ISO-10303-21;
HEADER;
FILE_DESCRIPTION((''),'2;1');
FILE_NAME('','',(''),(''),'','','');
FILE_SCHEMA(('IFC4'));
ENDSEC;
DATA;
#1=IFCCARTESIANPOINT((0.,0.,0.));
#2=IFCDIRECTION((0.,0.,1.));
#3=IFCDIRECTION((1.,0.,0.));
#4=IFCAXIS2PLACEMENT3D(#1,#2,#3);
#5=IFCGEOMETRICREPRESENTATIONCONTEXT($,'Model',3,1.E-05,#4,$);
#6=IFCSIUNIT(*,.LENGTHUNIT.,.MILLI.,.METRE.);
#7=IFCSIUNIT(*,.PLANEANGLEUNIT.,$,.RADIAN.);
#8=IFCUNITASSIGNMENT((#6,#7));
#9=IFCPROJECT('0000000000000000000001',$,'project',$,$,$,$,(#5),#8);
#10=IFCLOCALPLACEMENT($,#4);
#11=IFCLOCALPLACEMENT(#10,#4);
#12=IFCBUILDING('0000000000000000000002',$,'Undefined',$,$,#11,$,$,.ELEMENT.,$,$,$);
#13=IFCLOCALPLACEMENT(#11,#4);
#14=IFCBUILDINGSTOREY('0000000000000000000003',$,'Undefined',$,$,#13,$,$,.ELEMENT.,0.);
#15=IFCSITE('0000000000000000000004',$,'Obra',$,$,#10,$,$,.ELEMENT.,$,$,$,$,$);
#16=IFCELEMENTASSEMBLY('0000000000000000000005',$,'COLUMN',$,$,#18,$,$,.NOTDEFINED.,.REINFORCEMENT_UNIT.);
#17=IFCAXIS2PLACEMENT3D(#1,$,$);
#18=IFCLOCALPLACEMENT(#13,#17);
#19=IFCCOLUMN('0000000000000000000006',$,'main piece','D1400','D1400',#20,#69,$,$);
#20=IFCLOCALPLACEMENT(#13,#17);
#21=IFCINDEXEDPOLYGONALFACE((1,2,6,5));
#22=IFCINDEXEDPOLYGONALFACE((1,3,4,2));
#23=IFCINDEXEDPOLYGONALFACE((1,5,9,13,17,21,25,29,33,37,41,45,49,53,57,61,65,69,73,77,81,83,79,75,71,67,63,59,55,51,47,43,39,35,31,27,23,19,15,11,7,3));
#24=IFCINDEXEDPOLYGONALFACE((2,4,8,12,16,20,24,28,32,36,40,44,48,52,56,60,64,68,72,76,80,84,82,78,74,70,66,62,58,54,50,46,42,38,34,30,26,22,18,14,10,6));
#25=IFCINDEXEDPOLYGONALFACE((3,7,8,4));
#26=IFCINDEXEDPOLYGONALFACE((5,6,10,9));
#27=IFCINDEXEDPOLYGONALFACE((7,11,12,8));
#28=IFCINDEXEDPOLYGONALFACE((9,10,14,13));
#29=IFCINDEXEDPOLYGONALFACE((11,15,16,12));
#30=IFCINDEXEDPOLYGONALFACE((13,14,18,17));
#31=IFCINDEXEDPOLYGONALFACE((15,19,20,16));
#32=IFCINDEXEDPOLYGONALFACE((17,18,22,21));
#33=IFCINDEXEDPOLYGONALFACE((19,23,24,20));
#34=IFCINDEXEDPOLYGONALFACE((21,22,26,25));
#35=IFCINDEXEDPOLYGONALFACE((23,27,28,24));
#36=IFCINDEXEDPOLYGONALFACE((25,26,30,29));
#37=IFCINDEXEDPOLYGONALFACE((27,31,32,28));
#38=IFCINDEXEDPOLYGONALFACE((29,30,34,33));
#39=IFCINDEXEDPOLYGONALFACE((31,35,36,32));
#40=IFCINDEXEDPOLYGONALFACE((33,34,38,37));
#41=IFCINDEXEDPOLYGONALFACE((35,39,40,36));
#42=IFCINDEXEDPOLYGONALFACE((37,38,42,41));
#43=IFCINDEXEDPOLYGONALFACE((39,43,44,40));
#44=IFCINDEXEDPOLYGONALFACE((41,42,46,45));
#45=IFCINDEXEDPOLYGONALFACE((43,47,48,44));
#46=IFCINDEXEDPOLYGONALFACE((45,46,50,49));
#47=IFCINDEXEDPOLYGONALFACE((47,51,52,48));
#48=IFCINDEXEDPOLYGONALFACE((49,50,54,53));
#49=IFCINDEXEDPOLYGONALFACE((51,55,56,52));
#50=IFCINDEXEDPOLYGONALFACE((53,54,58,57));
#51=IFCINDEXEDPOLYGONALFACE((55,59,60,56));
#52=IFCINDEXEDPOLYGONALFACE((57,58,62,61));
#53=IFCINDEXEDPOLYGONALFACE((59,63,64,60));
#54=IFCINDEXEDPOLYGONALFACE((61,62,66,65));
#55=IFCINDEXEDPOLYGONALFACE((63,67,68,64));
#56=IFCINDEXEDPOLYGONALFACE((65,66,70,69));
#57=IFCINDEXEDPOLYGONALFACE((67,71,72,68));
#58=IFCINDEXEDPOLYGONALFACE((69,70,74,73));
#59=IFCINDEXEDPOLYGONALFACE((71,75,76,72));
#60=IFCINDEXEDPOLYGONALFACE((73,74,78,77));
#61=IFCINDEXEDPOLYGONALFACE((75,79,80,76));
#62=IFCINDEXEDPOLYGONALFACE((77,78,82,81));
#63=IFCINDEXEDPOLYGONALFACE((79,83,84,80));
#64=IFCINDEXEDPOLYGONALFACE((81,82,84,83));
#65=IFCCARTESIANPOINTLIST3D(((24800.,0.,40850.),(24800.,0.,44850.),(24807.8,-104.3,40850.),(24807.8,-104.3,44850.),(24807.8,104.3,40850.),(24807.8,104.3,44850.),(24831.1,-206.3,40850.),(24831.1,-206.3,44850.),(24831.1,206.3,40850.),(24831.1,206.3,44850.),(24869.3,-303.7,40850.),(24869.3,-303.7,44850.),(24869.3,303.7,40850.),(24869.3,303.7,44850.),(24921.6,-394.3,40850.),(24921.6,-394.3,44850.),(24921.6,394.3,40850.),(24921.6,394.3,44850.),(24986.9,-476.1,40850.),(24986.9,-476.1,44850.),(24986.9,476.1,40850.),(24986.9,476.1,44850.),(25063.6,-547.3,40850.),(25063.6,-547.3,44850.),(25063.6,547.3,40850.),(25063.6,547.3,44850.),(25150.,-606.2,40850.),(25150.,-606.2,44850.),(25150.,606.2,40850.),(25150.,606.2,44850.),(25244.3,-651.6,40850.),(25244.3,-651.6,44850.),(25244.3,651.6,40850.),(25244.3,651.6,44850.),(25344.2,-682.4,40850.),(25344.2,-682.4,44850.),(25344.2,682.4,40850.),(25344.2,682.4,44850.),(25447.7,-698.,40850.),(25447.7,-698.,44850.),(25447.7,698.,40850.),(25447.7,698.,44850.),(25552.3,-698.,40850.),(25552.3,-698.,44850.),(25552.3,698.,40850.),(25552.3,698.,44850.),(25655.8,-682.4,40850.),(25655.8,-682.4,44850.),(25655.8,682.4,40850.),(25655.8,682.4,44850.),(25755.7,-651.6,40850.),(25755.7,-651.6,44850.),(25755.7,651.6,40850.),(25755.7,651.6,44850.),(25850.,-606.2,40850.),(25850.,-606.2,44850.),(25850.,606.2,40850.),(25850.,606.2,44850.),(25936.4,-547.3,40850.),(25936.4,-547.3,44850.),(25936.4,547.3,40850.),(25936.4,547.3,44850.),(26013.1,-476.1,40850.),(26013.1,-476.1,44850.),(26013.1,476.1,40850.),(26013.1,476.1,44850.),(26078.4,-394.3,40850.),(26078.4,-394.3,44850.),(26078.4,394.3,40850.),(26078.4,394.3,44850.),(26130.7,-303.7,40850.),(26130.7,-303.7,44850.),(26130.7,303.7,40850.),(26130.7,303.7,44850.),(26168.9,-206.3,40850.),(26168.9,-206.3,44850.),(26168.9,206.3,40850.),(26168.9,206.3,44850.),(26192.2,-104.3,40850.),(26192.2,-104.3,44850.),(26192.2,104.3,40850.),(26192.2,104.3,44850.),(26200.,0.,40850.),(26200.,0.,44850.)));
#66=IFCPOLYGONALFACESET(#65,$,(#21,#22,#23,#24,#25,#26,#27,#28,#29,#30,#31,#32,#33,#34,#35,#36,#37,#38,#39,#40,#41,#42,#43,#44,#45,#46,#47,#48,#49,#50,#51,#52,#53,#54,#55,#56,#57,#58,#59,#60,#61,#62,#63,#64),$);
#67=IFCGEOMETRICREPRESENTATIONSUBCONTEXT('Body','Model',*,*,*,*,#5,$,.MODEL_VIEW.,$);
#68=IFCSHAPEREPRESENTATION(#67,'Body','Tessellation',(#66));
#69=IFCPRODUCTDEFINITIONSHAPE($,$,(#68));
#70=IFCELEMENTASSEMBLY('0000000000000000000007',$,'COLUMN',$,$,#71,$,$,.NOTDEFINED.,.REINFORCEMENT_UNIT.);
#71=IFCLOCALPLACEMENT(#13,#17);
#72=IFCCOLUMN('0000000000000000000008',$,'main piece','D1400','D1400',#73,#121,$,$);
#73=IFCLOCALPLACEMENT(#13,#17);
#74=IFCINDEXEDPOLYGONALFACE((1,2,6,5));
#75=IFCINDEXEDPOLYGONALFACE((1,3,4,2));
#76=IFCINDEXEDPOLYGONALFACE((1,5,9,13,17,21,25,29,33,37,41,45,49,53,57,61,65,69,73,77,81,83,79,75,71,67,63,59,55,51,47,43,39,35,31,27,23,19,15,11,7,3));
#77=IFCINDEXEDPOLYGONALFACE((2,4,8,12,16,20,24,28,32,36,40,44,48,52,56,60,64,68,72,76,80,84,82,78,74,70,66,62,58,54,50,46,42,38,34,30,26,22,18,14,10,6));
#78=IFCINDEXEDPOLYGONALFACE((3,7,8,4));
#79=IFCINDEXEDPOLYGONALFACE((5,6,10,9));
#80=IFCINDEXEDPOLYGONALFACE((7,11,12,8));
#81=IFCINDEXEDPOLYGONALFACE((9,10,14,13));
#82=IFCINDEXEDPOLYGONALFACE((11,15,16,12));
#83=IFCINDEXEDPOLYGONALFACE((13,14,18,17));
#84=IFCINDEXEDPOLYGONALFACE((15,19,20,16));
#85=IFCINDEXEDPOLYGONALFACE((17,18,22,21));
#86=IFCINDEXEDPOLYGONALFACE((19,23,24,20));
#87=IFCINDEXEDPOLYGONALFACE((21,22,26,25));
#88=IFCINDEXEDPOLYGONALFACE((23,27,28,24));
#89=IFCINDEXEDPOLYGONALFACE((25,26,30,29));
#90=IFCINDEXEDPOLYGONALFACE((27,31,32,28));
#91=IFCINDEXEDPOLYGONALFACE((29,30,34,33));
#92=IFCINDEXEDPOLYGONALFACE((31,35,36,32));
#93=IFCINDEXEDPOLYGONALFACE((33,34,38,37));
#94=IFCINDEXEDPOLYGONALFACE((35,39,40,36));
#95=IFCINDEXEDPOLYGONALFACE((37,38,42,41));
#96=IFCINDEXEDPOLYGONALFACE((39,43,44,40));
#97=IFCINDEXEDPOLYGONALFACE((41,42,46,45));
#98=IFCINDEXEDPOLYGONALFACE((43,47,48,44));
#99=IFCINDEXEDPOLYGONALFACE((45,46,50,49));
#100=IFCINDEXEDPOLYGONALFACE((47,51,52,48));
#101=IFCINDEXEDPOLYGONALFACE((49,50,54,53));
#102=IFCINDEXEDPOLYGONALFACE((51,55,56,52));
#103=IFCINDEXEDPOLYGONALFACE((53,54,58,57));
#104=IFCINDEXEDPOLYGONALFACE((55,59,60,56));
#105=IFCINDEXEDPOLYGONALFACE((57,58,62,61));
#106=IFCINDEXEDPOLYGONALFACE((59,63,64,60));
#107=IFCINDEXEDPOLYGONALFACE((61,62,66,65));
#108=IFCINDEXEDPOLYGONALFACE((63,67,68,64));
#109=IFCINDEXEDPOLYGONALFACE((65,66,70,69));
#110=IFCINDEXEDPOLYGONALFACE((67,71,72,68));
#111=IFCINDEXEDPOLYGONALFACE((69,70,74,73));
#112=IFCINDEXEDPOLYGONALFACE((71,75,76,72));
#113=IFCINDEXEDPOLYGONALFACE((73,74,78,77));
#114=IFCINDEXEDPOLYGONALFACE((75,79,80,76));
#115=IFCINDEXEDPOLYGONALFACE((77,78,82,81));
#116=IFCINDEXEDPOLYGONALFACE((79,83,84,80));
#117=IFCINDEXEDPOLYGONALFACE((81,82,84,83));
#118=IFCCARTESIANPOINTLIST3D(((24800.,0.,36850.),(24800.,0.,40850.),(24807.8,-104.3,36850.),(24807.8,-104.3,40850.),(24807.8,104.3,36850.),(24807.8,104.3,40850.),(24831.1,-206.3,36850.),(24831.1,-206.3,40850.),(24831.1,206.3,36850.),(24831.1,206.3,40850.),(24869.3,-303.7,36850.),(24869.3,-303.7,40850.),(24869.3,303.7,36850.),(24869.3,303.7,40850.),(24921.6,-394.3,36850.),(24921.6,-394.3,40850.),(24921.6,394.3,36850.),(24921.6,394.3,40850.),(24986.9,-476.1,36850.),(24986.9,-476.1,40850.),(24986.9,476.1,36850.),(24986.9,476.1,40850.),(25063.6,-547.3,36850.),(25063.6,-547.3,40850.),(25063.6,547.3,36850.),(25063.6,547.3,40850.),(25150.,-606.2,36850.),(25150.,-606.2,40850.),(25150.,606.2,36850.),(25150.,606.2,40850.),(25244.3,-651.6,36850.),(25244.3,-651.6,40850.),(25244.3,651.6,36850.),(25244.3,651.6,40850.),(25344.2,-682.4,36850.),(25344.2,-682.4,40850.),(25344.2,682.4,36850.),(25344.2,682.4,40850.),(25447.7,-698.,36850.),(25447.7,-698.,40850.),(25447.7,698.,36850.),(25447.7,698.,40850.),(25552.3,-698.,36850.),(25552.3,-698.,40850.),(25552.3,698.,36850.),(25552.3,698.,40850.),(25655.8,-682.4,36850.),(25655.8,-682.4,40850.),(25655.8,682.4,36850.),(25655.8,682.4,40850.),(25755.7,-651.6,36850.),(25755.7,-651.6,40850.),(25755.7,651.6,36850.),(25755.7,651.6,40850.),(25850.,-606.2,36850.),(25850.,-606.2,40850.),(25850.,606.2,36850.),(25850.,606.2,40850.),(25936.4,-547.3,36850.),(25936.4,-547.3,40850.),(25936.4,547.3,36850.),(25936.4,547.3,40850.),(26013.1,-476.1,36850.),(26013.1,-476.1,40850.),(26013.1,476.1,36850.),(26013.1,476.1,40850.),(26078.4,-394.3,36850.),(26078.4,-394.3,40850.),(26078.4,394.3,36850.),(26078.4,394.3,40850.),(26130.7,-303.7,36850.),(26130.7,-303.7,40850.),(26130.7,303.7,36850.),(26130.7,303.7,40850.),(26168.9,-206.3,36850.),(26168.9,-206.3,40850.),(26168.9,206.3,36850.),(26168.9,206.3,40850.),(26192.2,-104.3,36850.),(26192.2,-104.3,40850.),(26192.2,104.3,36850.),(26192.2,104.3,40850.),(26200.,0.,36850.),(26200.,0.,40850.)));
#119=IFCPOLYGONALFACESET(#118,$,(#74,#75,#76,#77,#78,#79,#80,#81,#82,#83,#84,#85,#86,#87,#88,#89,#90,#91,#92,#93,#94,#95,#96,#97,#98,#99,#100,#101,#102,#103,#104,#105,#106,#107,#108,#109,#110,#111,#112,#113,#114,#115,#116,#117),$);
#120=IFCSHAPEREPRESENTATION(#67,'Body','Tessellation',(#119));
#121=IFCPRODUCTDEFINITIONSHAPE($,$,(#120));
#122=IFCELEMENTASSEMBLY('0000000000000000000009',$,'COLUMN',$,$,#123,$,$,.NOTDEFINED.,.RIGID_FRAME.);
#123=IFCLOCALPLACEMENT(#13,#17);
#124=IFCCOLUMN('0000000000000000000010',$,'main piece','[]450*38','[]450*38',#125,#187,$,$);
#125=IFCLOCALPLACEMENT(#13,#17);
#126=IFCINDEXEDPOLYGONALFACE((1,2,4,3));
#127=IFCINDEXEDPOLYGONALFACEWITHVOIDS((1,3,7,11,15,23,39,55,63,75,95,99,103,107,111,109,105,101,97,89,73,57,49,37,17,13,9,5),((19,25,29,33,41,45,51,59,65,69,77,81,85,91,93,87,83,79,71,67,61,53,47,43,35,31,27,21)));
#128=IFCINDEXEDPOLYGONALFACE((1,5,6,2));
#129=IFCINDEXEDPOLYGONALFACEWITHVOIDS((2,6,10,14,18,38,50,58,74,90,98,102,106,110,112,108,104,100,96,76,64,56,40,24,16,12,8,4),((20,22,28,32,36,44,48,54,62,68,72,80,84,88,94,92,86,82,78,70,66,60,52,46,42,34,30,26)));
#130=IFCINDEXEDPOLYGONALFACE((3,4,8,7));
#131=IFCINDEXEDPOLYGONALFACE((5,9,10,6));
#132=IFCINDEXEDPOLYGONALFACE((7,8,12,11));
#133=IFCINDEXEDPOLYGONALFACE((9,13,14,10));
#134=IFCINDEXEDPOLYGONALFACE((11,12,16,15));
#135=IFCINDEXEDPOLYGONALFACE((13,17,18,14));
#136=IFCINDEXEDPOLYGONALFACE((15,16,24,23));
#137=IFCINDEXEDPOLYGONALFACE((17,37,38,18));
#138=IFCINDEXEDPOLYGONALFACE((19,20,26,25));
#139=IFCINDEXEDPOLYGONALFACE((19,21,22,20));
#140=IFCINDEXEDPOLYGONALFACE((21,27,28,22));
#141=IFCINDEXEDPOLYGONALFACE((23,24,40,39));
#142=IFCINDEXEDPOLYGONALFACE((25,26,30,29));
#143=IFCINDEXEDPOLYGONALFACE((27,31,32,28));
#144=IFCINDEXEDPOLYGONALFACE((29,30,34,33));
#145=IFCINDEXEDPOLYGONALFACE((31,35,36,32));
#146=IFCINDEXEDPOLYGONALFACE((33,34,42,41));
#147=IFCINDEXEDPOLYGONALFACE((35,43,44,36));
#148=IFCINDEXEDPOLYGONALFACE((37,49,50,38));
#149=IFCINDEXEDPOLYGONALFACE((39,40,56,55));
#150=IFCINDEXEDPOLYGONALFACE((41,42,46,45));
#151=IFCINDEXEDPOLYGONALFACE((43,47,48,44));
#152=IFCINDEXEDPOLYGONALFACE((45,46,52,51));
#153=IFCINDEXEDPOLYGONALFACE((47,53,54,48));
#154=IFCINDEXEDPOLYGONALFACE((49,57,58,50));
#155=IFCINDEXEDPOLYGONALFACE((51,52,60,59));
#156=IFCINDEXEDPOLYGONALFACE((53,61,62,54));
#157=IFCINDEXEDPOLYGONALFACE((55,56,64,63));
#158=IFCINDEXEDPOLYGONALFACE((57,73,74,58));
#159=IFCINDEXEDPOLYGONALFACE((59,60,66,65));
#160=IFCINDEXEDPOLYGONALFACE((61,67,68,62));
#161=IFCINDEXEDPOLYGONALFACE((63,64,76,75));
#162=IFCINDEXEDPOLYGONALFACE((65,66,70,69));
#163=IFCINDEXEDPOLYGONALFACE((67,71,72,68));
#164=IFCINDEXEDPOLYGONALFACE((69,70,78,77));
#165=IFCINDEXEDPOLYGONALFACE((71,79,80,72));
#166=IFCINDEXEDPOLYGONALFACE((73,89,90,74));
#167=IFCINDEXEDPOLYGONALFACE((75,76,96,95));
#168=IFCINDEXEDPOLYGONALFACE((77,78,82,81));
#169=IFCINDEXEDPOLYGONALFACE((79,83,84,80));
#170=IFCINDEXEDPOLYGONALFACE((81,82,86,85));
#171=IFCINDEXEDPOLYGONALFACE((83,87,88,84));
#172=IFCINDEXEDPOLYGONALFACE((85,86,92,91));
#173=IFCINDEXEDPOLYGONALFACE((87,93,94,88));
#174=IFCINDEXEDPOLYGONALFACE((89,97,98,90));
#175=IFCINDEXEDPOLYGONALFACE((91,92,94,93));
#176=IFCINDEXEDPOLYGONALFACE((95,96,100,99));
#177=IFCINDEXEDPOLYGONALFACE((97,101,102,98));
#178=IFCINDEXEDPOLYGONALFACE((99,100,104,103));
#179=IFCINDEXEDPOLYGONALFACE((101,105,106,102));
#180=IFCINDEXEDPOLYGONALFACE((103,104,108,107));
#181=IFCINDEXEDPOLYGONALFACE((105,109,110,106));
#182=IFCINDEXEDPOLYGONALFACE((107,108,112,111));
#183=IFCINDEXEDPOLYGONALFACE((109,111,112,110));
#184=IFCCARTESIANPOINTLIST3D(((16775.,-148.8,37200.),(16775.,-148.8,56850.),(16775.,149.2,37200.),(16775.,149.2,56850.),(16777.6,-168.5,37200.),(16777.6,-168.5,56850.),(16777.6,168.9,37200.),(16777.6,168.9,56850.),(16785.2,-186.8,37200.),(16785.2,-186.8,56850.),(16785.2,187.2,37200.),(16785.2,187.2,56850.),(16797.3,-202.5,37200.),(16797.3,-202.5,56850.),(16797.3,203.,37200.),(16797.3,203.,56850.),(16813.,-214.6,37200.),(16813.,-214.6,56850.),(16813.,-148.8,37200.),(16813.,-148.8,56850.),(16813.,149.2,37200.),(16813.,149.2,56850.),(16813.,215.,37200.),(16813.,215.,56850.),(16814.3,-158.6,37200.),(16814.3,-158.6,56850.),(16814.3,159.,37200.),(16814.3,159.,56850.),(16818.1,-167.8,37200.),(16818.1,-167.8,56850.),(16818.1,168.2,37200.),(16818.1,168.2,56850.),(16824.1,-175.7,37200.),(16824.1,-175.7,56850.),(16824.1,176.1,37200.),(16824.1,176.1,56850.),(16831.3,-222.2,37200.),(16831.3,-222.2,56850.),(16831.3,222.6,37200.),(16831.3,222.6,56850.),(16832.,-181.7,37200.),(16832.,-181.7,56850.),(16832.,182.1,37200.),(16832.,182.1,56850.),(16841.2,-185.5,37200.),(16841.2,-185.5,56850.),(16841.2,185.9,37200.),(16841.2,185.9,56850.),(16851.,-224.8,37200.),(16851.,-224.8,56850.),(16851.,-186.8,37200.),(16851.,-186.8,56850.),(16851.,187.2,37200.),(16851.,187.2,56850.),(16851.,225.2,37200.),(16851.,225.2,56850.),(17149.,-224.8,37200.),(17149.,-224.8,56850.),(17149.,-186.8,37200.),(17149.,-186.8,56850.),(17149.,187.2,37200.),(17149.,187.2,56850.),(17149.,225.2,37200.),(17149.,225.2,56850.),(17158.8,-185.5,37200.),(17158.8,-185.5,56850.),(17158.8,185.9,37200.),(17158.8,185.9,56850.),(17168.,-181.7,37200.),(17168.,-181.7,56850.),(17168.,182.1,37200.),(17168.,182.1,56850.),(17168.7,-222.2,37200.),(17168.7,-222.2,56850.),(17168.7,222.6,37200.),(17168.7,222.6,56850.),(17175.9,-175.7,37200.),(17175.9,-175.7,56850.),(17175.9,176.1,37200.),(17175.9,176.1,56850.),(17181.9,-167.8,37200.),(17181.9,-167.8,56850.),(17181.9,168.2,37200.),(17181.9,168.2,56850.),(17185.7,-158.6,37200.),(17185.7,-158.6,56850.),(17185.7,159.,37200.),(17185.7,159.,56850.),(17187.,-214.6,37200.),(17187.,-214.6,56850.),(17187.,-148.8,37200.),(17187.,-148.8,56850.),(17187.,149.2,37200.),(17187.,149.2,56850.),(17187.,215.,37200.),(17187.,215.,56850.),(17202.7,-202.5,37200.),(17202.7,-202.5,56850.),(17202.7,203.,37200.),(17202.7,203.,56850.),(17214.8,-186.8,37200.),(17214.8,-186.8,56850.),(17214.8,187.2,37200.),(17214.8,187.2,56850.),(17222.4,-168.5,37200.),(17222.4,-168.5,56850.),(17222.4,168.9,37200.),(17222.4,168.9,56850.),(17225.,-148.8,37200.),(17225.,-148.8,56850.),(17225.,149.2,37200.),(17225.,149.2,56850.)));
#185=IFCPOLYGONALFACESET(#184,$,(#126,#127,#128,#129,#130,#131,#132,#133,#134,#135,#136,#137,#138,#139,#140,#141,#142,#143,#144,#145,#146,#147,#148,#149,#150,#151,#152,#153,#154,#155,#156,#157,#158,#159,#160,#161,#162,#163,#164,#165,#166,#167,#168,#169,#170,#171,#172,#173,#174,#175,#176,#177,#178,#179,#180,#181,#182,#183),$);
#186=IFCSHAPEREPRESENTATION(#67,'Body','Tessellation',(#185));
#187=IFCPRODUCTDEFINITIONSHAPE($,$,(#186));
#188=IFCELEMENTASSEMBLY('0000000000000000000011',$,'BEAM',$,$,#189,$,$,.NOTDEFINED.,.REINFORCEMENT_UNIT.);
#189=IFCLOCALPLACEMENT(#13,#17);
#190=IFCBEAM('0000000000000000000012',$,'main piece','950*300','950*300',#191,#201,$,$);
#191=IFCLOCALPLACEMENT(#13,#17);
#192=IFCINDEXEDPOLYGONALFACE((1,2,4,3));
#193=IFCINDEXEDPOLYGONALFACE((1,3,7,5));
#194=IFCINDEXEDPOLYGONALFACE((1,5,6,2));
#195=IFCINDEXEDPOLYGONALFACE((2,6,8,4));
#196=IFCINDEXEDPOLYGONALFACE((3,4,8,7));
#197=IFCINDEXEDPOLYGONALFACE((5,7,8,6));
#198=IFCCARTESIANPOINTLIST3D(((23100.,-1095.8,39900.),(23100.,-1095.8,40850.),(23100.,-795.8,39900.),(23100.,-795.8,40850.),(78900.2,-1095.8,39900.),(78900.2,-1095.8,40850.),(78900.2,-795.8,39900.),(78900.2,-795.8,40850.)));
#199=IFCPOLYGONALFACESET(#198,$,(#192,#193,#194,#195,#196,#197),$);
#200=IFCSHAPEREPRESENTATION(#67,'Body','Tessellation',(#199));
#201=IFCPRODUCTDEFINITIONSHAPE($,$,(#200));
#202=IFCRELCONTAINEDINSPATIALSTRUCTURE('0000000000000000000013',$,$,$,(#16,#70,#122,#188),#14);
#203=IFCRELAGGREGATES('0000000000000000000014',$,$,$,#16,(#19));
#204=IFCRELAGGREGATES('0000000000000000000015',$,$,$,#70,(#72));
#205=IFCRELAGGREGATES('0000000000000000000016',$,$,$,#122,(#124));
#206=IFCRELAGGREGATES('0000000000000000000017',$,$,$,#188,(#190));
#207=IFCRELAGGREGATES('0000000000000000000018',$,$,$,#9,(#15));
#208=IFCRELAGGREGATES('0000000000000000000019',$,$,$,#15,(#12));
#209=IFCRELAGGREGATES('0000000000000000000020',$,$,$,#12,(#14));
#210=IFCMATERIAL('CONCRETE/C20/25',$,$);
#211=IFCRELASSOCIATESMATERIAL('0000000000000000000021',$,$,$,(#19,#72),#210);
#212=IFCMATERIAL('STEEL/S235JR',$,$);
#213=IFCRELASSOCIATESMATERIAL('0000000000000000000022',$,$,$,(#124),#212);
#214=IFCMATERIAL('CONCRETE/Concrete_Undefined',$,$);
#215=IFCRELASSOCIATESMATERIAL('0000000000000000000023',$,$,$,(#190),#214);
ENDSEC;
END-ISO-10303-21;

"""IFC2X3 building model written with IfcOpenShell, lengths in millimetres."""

from ifc_helpers import new_model, si_unit, frame, origin_with_axes, origin_2d_with_axis, place, context, subcontext, project, spatial, rectangle, hollow_rectangle, circle, extrude, material, element, aggregate, save


model = new_model("IFC2X3")

# Units and contexts
model_context = context("Model", 3, precision=1e-05, world=origin_with_axes())
body_context = subcontext(model_context, "Body", "Model", "MODEL_VIEW")
ifc_project = project(units=[si_unit("LENGTHUNIT", "METRE", prefix="MILLI"), si_unit("PLANEANGLEUNIT", "RADIAN")], contexts=[model_context])

# Site, building, storey
site_placement = place(None, origin_with_axes())
site = spatial("IfcSite", under=ifc_project, at=site_placement, Name="Obra", CompositionType="ELEMENT")
building_placement = place(site_placement, origin_with_axes())
building = spatial("IfcBuilding", under=site, at=building_placement, Name="Undefined", CompositionType="ELEMENT")
storey_placement = place(building_placement, origin_with_axes())
storey = spatial("IfcBuildingStorey", under=building, at=storey_placement, Name="Undefined", CompositionType="ELEMENT", Elevation=0.0)

# Element assemblies, columns
assembly_1_placement = place(storey_placement, origin_with_axes())
assembly_1 = element("IfcElementAssembly", 1, at=assembly_1_placement, inside=storey, Name="COLUMN", AssemblyPlace="NOTDEFINED", PredefinedType="REINFORCEMENT_UNIT")
ifc_material_1 = material(Name="CONCRETE/C20/25")
column_1_placement = place(assembly_1_placement, frame((25500.0, 0.0, 40850.0), z_axis=(0.0, 0.0, 1.0), x_axis=(0.0, 1.0, 0.0)))
column_1 = element("IfcColumn", 2, at=column_1_placement, material=ifc_material_1, Name="main piece", Description="D1400", ObjectType="D1400", context=body_context, shape_type="SweptSolid", body=[
    extrude(circle(Radius=700.0, at=origin_2d_with_axis()), frame((0.0, 0.0, 4000.0), z_axis=(0.0, 0.0, -1.0), x_axis=(0.0, 1.0, 0.0)), (0.0, 0.0, 1.0), 4000.0),
])
aggregate(assembly_1, [column_1])
assembly_2_placement = place(storey_placement, origin_with_axes())
assembly_2 = element("IfcElementAssembly", 3, at=assembly_2_placement, inside=storey, Name="COLUMN", AssemblyPlace="NOTDEFINED", PredefinedType="REINFORCEMENT_UNIT")
column_2_placement = place(assembly_2_placement, frame((25500.0, 0.0, 36850.0), z_axis=(0.0, 0.0, 1.0), x_axis=(0.0, 1.0, 0.0)))
column_2 = element("IfcColumn", 4, at=column_2_placement, material=ifc_material_1, Name="main piece", Description="D1400", ObjectType="D1400", context=body_context, shape_type="SweptSolid", body=[
    extrude(circle(Radius=700.0, at=origin_2d_with_axis()), frame((0.0, 0.0, 4000.0), z_axis=(0.0, 0.0, -1.0), x_axis=(0.0, 1.0, 0.0)), (0.0, 0.0, 1.0), 4000.0),
])
aggregate(assembly_2, [column_2])
assembly_3_placement = place(storey_placement, origin_with_axes())
assembly_3 = element("IfcElementAssembly", 5, at=assembly_3_placement, inside=storey, Name="COLUMN", AssemblyPlace="NOTDEFINED", PredefinedType="RIGID_FRAME")
ifc_material_2 = material(Name="STEEL/S235JR")
column_3_placement = place(assembly_3_placement, frame((17000.0, 0.2, 37200.0), z_axis=(0.0, 0.0, 1.0), x_axis=(0.0, 1.0, 0.0)))
column_3 = element("IfcColumn", 6, at=column_3_placement, material=ifc_material_2, Name="main piece", Description="[]450*38", ObjectType="[]450*38", context=body_context, shape_type="SweptSolid", body=[
    extrude(hollow_rectangle(XDim=450.0, YDim=450.0, WallThickness=38.0, InnerFilletRadius=38.0, OuterFilletRadius=76.0, at=origin_2d_with_axis()), frame((0.0, 0.0, 19650.0), z_axis=(0.0, 0.0, -1.0), x_axis=(0.0, 1.0, 0.0)), (0.0, 0.0, 1.0), 19650.0),
])
aggregate(assembly_3, [column_3])

# Element assembly, beam
assembly_4_placement = place(storey_placement, origin_with_axes())
assembly_4 = element("IfcElementAssembly", 7, at=assembly_4_placement, inside=storey, Name="BEAM", AssemblyPlace="NOTDEFINED", PredefinedType="REINFORCEMENT_UNIT")
ifc_material_3 = material(Name="CONCRETE/Concrete_Undefined")
beam_1_placement = place(assembly_4_placement, frame((23100.0, -945.8, 40375.0), z_axis=(0.0, 0.0, 1.0), x_axis=(1.0, 0.0, 0.0)))
beam_1 = element("IfcBeam", 8, at=beam_1_placement, material=ifc_material_3, Name="main piece", Description="950*300", ObjectType="950*300", context=body_context, shape_type="SweptSolid", body=[
    extrude(rectangle(XDim=300.0, YDim=950.0, at=origin_2d_with_axis()), frame((55800.2, 0.0, 0.0), z_axis=(-1.0, 0.0, 0.0), x_axis=(0.0, -1.0, 0.0)), (0.0, 0.0, 1.0), 55800.2),
])
aggregate(assembly_4, [beam_1])

save(model, "model.ifc")
